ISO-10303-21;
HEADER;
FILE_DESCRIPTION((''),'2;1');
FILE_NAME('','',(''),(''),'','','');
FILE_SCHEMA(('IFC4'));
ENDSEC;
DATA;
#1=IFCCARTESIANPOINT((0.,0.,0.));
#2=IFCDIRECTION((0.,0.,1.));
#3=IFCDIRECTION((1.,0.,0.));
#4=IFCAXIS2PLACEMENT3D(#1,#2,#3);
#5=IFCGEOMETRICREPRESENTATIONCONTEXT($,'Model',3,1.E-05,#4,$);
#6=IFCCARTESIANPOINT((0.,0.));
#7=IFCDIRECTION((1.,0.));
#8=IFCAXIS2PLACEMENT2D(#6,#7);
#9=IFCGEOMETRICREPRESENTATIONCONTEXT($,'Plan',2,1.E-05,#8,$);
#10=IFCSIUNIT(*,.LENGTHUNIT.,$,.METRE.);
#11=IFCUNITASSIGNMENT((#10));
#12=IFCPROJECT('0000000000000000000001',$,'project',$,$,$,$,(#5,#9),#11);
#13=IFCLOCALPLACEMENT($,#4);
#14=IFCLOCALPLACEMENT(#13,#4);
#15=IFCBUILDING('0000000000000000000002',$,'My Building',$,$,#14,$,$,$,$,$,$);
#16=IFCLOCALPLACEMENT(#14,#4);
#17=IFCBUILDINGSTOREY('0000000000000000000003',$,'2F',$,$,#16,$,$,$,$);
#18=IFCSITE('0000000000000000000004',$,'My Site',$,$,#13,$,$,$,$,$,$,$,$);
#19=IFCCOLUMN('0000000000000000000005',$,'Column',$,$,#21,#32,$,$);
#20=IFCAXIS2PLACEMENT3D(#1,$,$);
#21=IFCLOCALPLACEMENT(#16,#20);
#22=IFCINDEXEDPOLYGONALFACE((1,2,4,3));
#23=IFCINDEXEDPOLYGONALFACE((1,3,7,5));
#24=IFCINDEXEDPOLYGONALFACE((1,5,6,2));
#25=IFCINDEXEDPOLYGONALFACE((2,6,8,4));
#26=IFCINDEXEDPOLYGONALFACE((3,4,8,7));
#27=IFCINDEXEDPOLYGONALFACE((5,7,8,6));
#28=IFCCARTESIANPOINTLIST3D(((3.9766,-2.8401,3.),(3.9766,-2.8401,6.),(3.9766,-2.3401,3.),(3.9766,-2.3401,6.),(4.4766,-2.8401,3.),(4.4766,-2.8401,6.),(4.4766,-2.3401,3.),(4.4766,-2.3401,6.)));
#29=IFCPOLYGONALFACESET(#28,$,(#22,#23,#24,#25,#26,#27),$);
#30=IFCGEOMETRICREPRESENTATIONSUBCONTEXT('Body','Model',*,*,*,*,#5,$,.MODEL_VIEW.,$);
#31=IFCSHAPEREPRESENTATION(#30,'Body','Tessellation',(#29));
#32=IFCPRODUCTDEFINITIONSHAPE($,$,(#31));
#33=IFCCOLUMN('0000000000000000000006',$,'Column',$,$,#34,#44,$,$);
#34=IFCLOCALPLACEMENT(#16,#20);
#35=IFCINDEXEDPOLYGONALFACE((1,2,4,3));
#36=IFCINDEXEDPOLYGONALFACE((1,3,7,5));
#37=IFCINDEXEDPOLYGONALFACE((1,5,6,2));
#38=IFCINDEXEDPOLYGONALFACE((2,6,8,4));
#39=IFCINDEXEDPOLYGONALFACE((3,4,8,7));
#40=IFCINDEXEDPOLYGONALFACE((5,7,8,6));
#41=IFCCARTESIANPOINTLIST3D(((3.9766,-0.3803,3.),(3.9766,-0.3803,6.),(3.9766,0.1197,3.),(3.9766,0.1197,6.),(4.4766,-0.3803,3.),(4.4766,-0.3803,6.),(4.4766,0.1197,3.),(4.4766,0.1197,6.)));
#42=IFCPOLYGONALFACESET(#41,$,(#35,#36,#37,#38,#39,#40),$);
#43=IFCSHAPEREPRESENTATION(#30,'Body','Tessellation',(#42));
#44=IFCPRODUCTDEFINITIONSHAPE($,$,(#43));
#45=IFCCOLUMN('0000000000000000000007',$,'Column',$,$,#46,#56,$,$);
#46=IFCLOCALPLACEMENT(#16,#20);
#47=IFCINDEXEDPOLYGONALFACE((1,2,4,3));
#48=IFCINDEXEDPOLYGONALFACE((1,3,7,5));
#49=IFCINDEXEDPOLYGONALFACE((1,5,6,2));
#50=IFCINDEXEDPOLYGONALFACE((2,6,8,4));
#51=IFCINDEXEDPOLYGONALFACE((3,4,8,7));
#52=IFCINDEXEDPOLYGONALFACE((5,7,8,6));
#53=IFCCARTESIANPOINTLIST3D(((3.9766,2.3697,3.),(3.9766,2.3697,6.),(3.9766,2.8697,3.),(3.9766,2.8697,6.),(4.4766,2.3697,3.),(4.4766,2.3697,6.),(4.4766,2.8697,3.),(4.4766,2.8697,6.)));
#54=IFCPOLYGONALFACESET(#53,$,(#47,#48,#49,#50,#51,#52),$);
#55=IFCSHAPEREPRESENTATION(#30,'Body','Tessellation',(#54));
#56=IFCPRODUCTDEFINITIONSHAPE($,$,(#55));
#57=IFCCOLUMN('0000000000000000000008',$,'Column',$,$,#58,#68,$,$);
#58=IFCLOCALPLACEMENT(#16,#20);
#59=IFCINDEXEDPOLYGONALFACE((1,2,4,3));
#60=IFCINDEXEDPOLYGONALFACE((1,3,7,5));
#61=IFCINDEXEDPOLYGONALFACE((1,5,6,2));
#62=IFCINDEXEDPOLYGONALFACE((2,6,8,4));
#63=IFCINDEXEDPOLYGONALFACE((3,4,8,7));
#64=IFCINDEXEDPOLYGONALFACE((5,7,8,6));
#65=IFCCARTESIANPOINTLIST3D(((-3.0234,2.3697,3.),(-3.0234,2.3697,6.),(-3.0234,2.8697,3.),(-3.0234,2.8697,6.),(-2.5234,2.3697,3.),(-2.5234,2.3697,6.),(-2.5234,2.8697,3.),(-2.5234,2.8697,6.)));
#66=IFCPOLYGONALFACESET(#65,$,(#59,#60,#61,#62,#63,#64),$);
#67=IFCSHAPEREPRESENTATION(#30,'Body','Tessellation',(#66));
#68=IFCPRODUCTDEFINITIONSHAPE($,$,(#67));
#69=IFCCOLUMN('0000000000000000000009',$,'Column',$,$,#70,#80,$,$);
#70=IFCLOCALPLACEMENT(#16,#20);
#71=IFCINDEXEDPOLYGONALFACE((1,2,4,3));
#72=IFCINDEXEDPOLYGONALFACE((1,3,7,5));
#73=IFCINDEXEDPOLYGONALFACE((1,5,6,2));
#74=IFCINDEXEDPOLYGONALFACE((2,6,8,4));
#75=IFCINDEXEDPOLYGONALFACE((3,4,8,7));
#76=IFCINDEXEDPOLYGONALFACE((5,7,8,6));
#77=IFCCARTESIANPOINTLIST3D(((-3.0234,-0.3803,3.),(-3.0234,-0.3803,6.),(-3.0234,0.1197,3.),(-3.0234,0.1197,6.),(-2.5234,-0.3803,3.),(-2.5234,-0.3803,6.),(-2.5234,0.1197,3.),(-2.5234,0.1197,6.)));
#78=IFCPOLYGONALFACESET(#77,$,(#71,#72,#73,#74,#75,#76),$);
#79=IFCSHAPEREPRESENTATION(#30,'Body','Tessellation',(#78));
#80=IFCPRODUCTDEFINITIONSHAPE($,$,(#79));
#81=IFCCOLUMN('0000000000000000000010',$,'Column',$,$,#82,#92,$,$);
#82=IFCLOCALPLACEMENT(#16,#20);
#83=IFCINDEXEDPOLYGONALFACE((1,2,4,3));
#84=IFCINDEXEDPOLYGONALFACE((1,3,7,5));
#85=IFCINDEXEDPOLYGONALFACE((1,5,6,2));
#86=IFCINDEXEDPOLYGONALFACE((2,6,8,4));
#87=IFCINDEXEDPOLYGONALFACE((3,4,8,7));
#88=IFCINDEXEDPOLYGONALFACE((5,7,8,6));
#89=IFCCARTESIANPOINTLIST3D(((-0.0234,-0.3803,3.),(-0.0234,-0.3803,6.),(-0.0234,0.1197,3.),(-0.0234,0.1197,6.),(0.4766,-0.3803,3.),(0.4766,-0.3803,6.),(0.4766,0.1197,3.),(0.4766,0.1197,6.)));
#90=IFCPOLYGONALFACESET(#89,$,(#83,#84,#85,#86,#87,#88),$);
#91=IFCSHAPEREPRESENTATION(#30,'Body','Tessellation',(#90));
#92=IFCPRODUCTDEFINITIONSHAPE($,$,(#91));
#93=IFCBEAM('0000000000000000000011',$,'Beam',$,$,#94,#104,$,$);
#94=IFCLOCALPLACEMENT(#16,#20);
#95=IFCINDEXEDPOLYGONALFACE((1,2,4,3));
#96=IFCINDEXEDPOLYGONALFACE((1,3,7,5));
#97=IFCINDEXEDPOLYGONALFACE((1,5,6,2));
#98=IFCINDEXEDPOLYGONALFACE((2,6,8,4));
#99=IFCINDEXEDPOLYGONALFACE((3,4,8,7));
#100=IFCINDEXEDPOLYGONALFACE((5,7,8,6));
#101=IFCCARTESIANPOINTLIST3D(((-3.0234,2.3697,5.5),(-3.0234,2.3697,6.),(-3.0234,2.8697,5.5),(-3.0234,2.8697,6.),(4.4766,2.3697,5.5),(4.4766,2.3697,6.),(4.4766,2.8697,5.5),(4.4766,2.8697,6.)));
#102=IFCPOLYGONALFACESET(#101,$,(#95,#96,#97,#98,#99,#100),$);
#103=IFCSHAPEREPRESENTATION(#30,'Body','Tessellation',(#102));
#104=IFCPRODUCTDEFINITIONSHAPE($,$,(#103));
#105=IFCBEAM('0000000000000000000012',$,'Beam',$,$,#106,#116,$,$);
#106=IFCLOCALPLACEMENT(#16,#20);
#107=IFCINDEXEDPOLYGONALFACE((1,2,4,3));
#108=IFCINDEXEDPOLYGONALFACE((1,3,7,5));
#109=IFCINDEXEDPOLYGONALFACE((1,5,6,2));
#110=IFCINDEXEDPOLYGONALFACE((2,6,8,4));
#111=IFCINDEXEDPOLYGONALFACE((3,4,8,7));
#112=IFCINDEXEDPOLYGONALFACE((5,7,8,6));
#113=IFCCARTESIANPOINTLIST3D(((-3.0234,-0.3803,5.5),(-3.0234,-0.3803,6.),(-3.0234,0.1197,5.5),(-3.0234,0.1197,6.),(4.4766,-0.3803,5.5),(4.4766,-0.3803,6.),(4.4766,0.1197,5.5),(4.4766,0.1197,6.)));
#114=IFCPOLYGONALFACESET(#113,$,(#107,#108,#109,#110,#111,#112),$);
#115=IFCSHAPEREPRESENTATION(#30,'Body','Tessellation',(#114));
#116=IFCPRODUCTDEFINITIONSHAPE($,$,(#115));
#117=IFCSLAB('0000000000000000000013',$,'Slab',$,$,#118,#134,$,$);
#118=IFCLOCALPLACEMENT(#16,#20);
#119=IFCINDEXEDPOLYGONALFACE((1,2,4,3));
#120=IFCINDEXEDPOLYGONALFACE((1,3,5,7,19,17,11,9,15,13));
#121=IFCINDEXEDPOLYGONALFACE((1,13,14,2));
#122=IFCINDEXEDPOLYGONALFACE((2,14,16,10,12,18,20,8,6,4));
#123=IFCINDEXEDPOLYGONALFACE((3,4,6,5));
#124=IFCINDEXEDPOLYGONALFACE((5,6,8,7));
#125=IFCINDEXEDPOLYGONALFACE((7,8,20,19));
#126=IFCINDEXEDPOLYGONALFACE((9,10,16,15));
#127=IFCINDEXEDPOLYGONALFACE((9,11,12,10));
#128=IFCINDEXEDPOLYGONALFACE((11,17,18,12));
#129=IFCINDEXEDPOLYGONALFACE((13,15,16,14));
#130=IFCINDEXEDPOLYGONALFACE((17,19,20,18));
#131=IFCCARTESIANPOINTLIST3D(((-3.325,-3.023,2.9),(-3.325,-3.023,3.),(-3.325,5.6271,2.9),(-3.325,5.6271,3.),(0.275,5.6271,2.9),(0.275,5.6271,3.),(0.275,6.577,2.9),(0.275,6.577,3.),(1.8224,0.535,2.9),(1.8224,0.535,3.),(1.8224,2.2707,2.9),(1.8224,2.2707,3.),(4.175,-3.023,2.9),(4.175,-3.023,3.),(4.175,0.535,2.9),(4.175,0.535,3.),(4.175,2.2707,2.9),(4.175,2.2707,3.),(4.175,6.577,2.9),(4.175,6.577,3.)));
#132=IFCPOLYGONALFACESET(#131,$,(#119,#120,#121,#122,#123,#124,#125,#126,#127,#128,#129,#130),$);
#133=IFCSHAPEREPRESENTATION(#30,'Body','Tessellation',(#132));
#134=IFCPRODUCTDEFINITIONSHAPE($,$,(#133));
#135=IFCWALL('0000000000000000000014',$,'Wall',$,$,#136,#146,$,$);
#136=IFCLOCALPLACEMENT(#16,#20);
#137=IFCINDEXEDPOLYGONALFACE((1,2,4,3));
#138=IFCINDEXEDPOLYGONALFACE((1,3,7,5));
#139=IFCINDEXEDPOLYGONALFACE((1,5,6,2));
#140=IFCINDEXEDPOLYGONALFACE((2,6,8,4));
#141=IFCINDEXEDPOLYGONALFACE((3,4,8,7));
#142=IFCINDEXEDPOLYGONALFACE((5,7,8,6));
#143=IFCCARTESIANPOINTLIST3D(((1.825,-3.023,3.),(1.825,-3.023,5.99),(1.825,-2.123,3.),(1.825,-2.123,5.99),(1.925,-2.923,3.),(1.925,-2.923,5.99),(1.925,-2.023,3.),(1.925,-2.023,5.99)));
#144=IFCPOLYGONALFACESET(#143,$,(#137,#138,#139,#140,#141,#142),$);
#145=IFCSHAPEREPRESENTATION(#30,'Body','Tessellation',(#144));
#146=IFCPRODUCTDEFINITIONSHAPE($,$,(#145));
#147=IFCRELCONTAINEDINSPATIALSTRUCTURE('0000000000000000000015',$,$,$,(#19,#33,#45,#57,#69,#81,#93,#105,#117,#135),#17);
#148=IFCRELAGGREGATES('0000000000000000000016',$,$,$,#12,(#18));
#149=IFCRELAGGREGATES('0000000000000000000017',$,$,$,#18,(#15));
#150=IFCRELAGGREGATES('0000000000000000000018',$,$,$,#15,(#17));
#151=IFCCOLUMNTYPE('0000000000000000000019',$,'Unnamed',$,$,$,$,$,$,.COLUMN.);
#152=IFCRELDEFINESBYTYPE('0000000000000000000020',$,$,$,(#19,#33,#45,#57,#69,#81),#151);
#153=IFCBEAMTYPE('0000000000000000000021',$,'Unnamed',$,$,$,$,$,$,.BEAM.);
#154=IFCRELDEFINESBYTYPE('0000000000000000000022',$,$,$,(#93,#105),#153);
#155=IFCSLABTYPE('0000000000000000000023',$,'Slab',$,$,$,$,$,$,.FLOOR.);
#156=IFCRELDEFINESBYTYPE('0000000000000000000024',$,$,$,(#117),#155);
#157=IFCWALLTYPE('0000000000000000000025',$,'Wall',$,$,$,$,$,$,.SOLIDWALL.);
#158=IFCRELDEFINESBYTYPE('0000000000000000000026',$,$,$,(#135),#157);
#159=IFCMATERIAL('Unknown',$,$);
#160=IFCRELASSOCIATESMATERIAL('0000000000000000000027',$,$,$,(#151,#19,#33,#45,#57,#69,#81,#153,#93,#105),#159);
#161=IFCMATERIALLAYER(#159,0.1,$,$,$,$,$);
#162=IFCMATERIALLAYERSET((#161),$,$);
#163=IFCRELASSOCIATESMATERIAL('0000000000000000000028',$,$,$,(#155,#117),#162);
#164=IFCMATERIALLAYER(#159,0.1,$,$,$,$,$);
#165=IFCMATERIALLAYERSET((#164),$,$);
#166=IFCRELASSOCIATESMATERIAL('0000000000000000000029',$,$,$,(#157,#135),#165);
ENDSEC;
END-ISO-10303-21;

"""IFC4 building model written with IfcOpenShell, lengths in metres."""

from ifc_helpers import new_model, si_unit, frame, origin_with_axes, origin_2d_with_axis, place, context, subcontext, project, spatial, line, indexed_curve, rectangle, outline, extrude, material, layer, layer_set, layer_usage, material_profile, profile_set, profile_usage, type_object, element, save


model = new_model("IFC4")

# Units and contexts
model_context = context("Model", 3, precision=1e-05, world=origin_with_axes())
plan_context = context("Plan", 2, precision=1e-05, world=origin_2d_with_axis())
body_context_1 = subcontext(model_context, "Body", "Model", "MODEL_VIEW")
ifc_project = project(units=[si_unit("LENGTHUNIT", "METRE")], contexts=[model_context, plan_context])

# Site, building, storey
site_placement = place(None, origin_with_axes())
site = spatial("IfcSite", under=ifc_project, at=site_placement, Name="My Site")
building_placement = place(site_placement, origin_with_axes())
building = spatial("IfcBuilding", under=site, at=building_placement, Name="My Building")
storey_placement = place(building_placement, origin_with_axes())
storey = spatial("IfcBuildingStorey", under=building, at=storey_placement, Name="2F")

# Columns
ifc_material = material(Name="Unknown")
ifc_material_profile_1 = material_profile(ifc_material, rectangle(XDim=0.5, YDim=0.5))
ifc_profile_set_1 = profile_set([ifc_material_profile_1])
ifc_profile_usage_1 = profile_usage(ifc_profile_set_1, cardinal=5)
column_type = type_object("IfcColumnType", Name="Unnamed", PredefinedType="COLUMN", material=ifc_profile_set_1)
column_1_placement = place(storey_placement, frame((4.2266, -2.5901, 3.0), z_axis=(0.0, 0.0, 1.0), x_axis=(1.0, 0.0, 0.0)))
element("IfcColumn", 1, at=column_1_placement, inside=storey, type_object=column_type, material=ifc_profile_usage_1, Name="Column", context=body_context_1, shape_type="SweptSolid", body=[
    extrude(rectangle(XDim=0.5, YDim=0.5), origin_with_axes(), (0.0, 0.0, 1.0), 3.0),
])
ifc_profile_usage_2 = profile_usage(ifc_profile_set_1, cardinal=5)
column_2_placement = place(storey_placement, frame((4.2266, -0.1303, 3.0), z_axis=(0.0, 0.0, 1.0), x_axis=(1.0, 0.0, 0.0)))
element("IfcColumn", 2, at=column_2_placement, inside=storey, type_object=column_type, material=ifc_profile_usage_2, Name="Column", context=body_context_1, shape_type="SweptSolid", body=[
    extrude(rectangle(XDim=0.5, YDim=0.5), origin_with_axes(), (0.0, 0.0, 1.0), 3.0),
])
ifc_profile_usage_3 = profile_usage(ifc_profile_set_1, cardinal=5)
column_3_placement = place(storey_placement, frame((4.2266, 2.6197, 3.0), z_axis=(0.0, 0.0, 1.0), x_axis=(1.0, 0.0, 0.0)))
element("IfcColumn", 3, at=column_3_placement, inside=storey, type_object=column_type, material=ifc_profile_usage_3, Name="Column", context=body_context_1, shape_type="SweptSolid", body=[
    extrude(rectangle(XDim=0.5, YDim=0.5), origin_with_axes(), (0.0, 0.0, 1.0), 3.0),
])
ifc_profile_usage_4 = profile_usage(ifc_profile_set_1, cardinal=5)
column_4_placement = place(storey_placement, frame((-2.7734, 2.6197, 3.0), z_axis=(0.0, 0.0, 1.0), x_axis=(1.0, 0.0, 0.0)))
element("IfcColumn", 4, at=column_4_placement, inside=storey, type_object=column_type, material=ifc_profile_usage_4, Name="Column", context=body_context_1, shape_type="SweptSolid", body=[
    extrude(rectangle(XDim=0.5, YDim=0.5), origin_with_axes(), (0.0, 0.0, 1.0), 3.0),
])
ifc_profile_usage_5 = profile_usage(ifc_profile_set_1, cardinal=5)
column_5_placement = place(storey_placement, frame((-2.7734, -0.1303, 3.0), z_axis=(0.0, 0.0, 1.0), x_axis=(1.0, 0.0, 0.0)))
element("IfcColumn", 5, at=column_5_placement, inside=storey, type_object=column_type, material=ifc_profile_usage_5, Name="Column", context=body_context_1, shape_type="SweptSolid", body=[
    extrude(rectangle(XDim=0.5, YDim=0.5), origin_with_axes(), (0.0, 0.0, 1.0), 3.0),
])
ifc_profile_usage_6 = profile_usage(ifc_profile_set_1, cardinal=5)
column_6_placement = place(storey_placement, frame((0.2266, -0.1303, 3.0), z_axis=(0.0, 0.0, 1.0), x_axis=(1.0, 0.0, 0.0)))
element("IfcColumn", 6, at=column_6_placement, inside=storey, type_object=column_type, material=ifc_profile_usage_6, Name="Column", context=body_context_1, shape_type="SweptSolid", body=[
    extrude(rectangle(XDim=0.5, YDim=0.5), origin_with_axes(), (0.0, 0.0, 1.0), 3.0),
])

# Beams
ifc_material_profile_2 = material_profile(ifc_material, rectangle(XDim=0.5, YDim=0.5))
ifc_profile_set_2 = profile_set([ifc_material_profile_2])
ifc_profile_usage_7 = profile_usage(ifc_profile_set_2, cardinal=7)
beam_type = type_object("IfcBeamType", Name="Unnamed", PredefinedType="BEAM", material=ifc_profile_set_2)
beam_1_placement = place(storey_placement, frame((4.4766, 2.3697, 6.0), z_axis=(-1.0, 0.0, 0.0), x_axis=(0.0, -1.0, 0.0)))
element("IfcBeam", 7, at=beam_1_placement, inside=storey, type_object=beam_type, material=ifc_profile_usage_7, Name="Beam", context=body_context_1, shape_type="SweptSolid", body=[
    extrude(rectangle(XDim=0.5, YDim=0.5), frame((-0.25, -0.25, 0.0), z_axis=(0.0, 0.0, 1.0), x_axis=(1.0, 0.0, 0.0)), (0.0, 0.0, 1.0), 7.5),
])
ifc_profile_usage_8 = profile_usage(ifc_profile_set_2, cardinal=7)
beam_2_placement = place(storey_placement, frame((4.4766, -0.3803, 6.0), z_axis=(-1.0, 0.0, 0.0), x_axis=(0.0, -1.0, 0.0)))
element("IfcBeam", 8, at=beam_2_placement, inside=storey, type_object=beam_type, material=ifc_profile_usage_8, Name="Beam", context=body_context_1, shape_type="SweptSolid", body=[
    extrude(rectangle(XDim=0.5, YDim=0.5), frame((-0.25, -0.25, 0.0), z_axis=(0.0, 0.0, 1.0), x_axis=(1.0, 0.0, 0.0)), (0.0, 0.0, 1.0), 7.5),
])

# Slab
ifc_layer_1 = layer(ifc_material, 0.1)
ifc_layer_set_1 = layer_set([ifc_layer_1])
ifc_layer_usage_1 = layer_usage(ifc_layer_set_1, "AXIS3", "POSITIVE", -0.1)
slab_type = type_object("IfcSlabType", Name="Slab", PredefinedType="FLOOR", material=ifc_layer_set_1)
slab_placement = place(storey_placement, frame((4.175, -3.023, 3.0), z_axis=(0.0, 0.0, 1.0), x_axis=(1.0, 0.0, 0.0)))
element("IfcSlab", 9, at=slab_placement, inside=storey, type_object=slab_type, material=ifc_layer_usage_1, Name="Slab", context=body_context_1, shape_type="SweptSolid", body=[
    extrude(outline(indexed_curve([(0.0, 0.0), (0.0, 3.5579), (-2.3526, 3.5579), (-2.3526, 5.2937), (0.0, 5.2937), (0.0, 9.6), (-3.9, 9.6), (-3.9, 8.65), (-7.5, 8.65), (-7.5, 0.0), (0.0, 0.0)])), frame((0.0, 0.0, -0.1), z_axis=(0.0, 0.0, 1.0), x_axis=(1.0, 0.0, 0.0)), (0.0, 0.0, 1.0), 0.1),
])

# Wall
ifc_layer_2 = layer(ifc_material, 0.1)
ifc_layer_set_2 = layer_set([ifc_layer_2])
ifc_layer_usage_2 = layer_usage(ifc_layer_set_2, "AXIS2", "POSITIVE", 0.0)
wall_type = type_object("IfcWallType", Name="Wall", PredefinedType="SOLIDWALL", material=ifc_layer_set_2)
wall_1_placement = place(storey_placement, frame((1.825, -2.123, 3.0), z_axis=(0.0, 0.0, 1.0), x_axis=(0.0, -1.0, 0.0)))
element("IfcWall", 10, at=wall_1_placement, inside=storey, type_object=wall_type, material=ifc_layer_usage_2, Name="Wall", context=body_context_1, shape_type="SweptSolid", body=[
    extrude(outline(indexed_curve([(0.0, 0.0), (-0.1, 0.1), (0.8, 0.1), (0.9, 0.0)], segments=[line(1, 2, 3, 4, 1)])), origin_with_axes(), (0.0, 0.0, 1.0), 2.99),
])

save(model, "model.ifc")
